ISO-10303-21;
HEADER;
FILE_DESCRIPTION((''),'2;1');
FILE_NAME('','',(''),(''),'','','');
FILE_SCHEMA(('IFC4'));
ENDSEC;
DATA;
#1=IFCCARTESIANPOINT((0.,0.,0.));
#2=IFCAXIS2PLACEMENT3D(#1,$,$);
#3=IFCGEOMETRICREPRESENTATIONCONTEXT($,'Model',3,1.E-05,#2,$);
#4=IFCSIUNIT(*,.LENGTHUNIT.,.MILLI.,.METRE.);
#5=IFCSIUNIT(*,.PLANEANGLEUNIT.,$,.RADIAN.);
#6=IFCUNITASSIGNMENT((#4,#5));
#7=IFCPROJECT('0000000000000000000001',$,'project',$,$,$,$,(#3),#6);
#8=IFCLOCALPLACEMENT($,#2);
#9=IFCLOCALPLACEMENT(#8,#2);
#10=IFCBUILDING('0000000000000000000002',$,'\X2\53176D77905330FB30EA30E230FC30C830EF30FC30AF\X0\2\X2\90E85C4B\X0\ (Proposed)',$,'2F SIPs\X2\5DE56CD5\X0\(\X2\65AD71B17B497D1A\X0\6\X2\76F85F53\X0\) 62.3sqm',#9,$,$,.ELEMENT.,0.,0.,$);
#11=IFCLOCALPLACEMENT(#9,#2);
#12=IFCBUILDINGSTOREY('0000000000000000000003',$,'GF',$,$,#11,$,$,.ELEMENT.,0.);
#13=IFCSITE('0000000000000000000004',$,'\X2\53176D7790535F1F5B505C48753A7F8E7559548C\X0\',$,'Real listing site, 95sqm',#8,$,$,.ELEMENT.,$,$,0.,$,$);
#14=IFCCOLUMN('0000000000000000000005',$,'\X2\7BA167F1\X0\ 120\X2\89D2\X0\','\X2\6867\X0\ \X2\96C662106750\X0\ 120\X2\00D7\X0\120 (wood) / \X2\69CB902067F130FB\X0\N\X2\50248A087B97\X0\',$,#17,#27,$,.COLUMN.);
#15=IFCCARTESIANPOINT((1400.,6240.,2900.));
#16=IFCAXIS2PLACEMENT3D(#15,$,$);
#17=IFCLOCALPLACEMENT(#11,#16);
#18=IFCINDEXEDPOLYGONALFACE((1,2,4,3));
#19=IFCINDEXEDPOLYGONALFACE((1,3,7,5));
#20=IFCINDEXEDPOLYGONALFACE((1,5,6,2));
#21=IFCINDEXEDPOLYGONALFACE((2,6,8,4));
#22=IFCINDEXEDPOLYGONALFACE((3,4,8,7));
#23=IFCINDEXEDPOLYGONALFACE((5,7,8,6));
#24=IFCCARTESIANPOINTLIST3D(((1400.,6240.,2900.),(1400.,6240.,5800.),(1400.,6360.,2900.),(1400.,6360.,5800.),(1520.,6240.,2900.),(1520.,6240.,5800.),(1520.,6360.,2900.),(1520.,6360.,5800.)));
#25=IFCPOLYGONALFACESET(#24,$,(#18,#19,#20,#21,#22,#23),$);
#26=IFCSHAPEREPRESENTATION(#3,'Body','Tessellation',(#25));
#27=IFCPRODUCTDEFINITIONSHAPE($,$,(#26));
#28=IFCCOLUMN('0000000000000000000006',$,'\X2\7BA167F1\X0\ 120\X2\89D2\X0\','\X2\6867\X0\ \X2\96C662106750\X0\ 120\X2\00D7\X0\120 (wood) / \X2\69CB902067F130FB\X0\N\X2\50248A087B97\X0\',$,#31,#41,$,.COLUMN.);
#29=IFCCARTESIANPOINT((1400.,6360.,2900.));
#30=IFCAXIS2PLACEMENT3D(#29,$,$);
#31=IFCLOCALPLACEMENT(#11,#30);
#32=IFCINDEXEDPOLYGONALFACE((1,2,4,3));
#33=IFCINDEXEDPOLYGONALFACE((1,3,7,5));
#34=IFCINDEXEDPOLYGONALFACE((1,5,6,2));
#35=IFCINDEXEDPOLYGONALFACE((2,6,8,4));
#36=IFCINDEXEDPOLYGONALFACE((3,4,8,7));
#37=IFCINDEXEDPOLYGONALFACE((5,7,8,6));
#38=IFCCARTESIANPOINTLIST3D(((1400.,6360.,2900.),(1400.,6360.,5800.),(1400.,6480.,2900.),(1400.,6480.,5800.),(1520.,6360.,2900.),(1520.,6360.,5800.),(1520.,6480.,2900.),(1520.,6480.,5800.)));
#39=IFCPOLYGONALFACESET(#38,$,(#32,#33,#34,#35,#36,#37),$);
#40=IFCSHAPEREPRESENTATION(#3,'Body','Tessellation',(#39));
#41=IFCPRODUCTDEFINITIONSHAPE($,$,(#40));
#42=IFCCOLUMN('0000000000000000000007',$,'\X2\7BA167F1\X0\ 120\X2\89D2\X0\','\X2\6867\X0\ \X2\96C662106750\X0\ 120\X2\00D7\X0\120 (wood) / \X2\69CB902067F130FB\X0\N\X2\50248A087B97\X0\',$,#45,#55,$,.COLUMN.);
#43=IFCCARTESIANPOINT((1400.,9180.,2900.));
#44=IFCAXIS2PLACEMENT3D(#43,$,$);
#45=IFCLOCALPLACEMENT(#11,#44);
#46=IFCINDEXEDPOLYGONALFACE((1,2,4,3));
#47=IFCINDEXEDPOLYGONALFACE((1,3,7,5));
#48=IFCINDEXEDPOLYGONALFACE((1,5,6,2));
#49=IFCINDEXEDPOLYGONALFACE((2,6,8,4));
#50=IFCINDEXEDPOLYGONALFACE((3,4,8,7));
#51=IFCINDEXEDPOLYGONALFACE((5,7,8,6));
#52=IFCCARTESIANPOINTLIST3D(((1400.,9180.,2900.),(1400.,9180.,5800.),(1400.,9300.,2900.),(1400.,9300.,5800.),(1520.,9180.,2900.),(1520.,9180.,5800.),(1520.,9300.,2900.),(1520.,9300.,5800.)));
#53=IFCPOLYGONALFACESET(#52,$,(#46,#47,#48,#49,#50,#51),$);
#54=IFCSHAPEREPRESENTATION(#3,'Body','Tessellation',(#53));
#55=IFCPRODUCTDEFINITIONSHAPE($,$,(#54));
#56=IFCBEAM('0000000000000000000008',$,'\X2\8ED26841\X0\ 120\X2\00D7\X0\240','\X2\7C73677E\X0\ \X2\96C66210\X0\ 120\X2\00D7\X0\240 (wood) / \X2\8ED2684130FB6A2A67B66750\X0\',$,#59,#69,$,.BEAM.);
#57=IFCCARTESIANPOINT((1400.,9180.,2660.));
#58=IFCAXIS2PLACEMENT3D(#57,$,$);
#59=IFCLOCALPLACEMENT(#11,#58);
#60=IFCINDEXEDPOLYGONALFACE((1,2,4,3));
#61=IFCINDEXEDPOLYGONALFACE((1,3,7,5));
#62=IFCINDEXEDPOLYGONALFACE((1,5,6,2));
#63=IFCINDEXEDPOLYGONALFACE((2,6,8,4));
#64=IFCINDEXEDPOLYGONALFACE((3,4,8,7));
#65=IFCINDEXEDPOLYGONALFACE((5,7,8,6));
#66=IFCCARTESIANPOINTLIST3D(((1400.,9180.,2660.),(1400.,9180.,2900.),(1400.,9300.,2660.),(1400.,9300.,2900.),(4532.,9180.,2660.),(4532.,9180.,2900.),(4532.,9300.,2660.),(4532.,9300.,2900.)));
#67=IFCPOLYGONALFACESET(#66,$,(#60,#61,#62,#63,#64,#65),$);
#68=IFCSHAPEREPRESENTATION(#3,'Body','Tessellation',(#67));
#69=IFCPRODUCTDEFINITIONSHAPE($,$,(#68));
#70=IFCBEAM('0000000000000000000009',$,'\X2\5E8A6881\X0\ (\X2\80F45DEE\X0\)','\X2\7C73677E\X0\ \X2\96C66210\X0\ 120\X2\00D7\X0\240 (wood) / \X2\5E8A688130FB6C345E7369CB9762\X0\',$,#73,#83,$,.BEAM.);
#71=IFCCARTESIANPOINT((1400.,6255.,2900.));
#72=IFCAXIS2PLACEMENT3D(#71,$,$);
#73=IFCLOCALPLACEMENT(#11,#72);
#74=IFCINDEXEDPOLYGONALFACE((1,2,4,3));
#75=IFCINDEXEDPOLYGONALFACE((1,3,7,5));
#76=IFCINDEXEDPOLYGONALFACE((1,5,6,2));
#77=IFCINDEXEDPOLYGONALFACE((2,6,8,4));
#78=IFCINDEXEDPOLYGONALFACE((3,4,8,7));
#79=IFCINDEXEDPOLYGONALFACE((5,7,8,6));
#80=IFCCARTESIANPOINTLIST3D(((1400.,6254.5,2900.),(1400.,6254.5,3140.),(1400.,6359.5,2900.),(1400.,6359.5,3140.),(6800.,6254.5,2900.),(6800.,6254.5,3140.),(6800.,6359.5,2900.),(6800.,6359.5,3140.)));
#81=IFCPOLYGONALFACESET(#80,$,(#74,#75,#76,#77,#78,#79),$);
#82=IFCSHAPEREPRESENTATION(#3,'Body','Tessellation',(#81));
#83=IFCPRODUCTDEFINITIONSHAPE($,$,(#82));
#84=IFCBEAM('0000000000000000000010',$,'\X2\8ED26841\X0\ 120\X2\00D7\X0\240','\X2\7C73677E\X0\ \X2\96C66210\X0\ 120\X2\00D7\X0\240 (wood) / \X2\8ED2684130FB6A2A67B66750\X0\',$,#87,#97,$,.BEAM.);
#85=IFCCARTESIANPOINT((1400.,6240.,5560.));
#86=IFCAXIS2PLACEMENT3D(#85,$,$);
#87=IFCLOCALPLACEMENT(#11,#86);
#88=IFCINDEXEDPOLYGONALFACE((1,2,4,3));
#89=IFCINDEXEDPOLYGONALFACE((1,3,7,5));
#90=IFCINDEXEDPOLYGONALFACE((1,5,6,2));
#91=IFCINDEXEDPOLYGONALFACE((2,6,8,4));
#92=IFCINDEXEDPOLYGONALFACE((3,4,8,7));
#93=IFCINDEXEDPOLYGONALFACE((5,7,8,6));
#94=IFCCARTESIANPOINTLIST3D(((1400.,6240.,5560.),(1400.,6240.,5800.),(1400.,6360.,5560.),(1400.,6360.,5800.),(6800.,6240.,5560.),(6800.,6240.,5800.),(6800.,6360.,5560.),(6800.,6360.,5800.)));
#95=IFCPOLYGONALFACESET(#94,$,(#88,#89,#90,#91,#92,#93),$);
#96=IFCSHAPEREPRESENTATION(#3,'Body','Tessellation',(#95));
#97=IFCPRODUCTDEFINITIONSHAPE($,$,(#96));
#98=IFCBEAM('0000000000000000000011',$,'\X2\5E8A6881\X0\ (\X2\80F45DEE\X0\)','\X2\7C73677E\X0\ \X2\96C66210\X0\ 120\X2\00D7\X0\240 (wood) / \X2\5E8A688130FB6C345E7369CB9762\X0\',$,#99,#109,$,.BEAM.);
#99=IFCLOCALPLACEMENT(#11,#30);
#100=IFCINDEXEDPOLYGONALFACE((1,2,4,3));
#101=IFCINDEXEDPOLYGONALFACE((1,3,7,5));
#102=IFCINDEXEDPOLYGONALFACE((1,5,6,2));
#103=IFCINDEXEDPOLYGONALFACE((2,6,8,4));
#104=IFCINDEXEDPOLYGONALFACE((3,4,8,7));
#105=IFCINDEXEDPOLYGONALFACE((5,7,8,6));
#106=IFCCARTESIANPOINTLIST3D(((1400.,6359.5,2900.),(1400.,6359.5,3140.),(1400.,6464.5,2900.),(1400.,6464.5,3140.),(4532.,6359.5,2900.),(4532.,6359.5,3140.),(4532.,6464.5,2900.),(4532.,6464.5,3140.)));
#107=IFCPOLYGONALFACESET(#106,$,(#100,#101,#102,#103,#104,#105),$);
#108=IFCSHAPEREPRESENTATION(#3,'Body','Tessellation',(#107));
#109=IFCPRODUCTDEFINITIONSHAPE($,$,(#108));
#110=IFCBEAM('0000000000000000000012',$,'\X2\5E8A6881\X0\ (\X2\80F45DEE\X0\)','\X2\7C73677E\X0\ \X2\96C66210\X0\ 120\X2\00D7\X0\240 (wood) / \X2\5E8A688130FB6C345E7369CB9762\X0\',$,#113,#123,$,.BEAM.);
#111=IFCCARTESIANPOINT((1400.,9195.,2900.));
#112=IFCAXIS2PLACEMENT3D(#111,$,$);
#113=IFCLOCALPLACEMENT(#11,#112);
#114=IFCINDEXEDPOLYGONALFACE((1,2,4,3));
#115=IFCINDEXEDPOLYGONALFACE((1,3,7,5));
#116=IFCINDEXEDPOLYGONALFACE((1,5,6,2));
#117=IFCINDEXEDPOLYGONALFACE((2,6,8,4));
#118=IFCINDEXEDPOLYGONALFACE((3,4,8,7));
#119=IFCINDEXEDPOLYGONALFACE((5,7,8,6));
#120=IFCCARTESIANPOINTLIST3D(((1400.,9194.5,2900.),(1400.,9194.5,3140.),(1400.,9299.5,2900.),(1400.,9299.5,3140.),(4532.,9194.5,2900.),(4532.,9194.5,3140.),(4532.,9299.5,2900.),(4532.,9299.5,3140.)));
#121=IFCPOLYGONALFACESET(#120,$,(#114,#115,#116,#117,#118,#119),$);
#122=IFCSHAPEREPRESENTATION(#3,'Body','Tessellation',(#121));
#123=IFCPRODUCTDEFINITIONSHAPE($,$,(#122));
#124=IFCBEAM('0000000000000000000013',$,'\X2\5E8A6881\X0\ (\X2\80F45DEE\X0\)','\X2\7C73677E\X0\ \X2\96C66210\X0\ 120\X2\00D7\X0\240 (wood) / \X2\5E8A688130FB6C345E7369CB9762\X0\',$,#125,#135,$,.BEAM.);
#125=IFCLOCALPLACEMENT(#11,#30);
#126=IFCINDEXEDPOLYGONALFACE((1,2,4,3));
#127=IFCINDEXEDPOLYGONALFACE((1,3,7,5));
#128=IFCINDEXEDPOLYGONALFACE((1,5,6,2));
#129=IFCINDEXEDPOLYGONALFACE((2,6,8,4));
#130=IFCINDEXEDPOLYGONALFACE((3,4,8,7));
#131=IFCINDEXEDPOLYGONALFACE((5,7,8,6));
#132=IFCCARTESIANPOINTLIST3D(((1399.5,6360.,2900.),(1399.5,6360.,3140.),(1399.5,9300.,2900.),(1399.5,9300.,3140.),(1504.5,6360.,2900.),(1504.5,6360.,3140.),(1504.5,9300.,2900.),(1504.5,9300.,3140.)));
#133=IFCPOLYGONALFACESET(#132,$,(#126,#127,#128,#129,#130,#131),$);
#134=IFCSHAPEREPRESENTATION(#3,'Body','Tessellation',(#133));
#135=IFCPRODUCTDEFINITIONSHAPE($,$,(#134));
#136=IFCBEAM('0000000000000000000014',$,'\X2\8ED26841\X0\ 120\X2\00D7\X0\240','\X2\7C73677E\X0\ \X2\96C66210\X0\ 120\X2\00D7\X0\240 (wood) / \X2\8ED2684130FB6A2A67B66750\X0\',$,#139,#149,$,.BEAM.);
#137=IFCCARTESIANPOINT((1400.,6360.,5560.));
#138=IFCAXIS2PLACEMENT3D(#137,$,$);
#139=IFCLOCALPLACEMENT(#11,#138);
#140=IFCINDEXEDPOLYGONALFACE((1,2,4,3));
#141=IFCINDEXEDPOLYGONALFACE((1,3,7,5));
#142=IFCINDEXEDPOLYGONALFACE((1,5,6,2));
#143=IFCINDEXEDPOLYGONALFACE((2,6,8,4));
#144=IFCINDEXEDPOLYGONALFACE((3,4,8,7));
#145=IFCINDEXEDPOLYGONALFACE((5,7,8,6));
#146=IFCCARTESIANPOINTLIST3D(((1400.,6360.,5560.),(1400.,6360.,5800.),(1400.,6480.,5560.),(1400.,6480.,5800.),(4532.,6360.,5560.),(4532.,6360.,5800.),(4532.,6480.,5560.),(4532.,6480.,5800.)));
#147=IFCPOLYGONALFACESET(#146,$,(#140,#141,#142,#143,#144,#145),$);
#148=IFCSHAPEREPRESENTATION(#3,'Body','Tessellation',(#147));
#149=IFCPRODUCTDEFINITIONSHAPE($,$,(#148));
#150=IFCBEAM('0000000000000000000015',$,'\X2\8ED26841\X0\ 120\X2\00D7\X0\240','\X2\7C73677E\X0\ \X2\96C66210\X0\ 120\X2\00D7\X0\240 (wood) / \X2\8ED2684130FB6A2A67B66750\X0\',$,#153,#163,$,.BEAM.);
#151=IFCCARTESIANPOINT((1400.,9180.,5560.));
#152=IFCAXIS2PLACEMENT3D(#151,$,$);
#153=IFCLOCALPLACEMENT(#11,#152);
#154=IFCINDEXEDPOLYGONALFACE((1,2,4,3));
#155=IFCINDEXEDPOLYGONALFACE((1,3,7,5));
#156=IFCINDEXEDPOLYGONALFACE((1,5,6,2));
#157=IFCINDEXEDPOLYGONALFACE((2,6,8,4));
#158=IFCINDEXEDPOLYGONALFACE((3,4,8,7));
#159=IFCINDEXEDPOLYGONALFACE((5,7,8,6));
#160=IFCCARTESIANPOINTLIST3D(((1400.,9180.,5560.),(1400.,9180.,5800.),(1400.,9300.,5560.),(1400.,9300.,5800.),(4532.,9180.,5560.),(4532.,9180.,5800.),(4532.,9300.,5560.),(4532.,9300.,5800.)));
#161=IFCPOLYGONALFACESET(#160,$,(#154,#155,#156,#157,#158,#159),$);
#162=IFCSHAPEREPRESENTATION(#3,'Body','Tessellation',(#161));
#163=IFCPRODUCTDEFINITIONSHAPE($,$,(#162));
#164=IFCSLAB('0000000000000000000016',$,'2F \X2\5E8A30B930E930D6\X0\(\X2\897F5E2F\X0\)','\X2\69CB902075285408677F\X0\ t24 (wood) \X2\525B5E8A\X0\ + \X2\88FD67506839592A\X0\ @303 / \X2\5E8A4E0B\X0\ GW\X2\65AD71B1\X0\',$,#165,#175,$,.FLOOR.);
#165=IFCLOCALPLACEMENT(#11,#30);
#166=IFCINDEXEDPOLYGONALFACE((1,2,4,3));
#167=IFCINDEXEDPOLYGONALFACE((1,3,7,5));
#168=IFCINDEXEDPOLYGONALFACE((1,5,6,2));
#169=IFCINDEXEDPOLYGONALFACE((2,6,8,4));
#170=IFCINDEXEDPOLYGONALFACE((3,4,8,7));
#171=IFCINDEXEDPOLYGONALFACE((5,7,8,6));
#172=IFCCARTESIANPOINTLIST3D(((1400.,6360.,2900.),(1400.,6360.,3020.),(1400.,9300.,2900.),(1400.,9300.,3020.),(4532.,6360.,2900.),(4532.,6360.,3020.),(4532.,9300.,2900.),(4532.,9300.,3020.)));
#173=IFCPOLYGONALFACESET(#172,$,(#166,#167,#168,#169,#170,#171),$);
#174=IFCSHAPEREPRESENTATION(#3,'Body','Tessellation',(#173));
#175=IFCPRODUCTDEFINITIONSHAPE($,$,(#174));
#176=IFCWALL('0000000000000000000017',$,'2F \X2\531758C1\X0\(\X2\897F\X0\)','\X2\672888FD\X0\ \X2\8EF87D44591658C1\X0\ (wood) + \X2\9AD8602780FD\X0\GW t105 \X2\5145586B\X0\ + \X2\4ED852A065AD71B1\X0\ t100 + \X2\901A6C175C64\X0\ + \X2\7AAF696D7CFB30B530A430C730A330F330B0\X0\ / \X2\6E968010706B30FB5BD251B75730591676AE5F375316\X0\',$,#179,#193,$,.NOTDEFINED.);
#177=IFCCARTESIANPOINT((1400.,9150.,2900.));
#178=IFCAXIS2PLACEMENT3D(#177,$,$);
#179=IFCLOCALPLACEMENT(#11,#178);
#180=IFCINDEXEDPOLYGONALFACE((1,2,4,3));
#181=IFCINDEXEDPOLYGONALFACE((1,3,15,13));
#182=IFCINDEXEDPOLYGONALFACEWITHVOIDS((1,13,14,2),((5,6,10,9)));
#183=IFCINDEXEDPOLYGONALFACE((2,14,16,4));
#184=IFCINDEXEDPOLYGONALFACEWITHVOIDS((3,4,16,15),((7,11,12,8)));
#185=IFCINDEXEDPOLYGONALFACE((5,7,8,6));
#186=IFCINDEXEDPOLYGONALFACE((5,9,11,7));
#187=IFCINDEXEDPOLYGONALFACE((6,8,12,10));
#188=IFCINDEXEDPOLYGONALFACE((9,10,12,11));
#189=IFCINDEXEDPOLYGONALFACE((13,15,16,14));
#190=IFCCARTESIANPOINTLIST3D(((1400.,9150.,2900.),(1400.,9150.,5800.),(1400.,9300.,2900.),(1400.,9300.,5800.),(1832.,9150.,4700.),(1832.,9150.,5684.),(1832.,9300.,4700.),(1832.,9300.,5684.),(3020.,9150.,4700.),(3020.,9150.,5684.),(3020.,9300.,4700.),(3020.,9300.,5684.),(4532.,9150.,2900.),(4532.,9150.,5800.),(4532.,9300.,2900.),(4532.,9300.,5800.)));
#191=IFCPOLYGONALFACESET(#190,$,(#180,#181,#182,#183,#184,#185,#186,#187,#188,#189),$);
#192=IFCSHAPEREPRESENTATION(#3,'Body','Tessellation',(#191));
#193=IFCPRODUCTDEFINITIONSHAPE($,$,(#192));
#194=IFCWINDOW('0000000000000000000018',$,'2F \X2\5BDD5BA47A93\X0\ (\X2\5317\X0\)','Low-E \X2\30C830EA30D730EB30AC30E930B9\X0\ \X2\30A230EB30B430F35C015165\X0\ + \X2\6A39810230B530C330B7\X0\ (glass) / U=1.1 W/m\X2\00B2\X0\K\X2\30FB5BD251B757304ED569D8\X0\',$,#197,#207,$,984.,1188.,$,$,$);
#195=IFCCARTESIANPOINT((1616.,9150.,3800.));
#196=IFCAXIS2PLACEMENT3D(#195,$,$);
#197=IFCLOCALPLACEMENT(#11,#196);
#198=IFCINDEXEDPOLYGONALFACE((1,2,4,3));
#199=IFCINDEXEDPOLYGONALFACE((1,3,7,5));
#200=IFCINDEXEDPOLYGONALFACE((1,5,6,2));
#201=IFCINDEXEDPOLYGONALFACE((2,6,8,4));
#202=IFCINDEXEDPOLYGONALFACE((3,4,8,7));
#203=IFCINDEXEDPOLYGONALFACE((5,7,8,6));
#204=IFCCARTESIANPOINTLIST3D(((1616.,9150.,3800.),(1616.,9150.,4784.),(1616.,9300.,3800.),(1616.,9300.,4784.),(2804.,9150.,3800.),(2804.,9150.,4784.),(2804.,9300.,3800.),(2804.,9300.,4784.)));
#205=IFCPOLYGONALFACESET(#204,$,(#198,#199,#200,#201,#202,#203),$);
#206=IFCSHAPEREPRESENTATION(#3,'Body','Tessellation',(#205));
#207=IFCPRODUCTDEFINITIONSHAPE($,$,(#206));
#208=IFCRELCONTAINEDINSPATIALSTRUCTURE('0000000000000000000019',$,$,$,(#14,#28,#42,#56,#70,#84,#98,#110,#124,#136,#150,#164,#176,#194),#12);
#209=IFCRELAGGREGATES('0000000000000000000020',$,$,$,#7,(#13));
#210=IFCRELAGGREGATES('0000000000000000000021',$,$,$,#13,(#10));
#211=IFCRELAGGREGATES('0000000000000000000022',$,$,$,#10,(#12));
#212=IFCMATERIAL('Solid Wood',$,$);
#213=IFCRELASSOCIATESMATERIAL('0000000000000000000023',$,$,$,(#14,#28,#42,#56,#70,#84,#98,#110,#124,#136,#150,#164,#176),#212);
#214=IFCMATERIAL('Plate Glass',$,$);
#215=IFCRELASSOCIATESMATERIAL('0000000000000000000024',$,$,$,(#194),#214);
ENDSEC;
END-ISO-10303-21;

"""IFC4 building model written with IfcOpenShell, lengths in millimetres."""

from ifc_helpers import new_model, si_unit, frame, frame_2d, origin, place, context, project, spatial, rectangle, extrude, material, element, fill, save


model = new_model("IFC4")

# Units and contexts
model_context = context("Model", 3, precision=1e-05, world=origin())
ifc_project = project(units=[si_unit("LENGTHUNIT", "METRE", prefix="MILLI"), si_unit("PLANEANGLEUNIT", "RADIAN")], contexts=[model_context])

# Site, building, storey
site_placement = place(None, origin())
site = spatial("IfcSite", under=ifc_project, at=site_placement, Name="北海道弟子屈町美留和", ObjectType="Real listing site, 95sqm", CompositionType="ELEMENT", RefElevation=0.0)
building_placement = place(site_placement, origin())
building = spatial("IfcBuilding", under=site, at=building_placement, Name="北海道・リモートワーク2部屋 (Proposed)", ObjectType="2F SIPs工法(断熱等級6相当) 62.3sqm", CompositionType="ELEMENT", ElevationOfRefHeight=0.0, ElevationOfTerrain=0.0)
storey_placement = place(building_placement, origin())
storey = spatial("IfcBuildingStorey", under=building, at=storey_placement, Name="GF", CompositionType="ELEMENT", Elevation=0.0)

# Columns
ifc_material_1 = material(Name="Solid Wood")
column_1_placement = place(storey_placement, frame((1400.0, 6240.0, 2900.0)))
element("IfcColumn", 1, at=column_1_placement, inside=storey, material=ifc_material_1, Name="管柱 120角", Description="桧 集成材 120×120 (wood) / 構造柱・N値計算", PredefinedType="COLUMN", context=model_context, shape_type="SweptSolid", body=[
    extrude(rectangle(XDim=120.0, YDim=120.0, at=frame_2d((60.0, 60.0))), frame((1400.0, 6240.0, 2900.0)), (0.0, 0.0, 1.0), 2900.0),
])
column_2_placement = place(storey_placement, frame((1400.0, 6360.0, 2900.0)))
element("IfcColumn", 2, at=column_2_placement, inside=storey, material=ifc_material_1, Name="管柱 120角", Description="桧 集成材 120×120 (wood) / 構造柱・N値計算", PredefinedType="COLUMN", context=model_context, shape_type="SweptSolid", body=[
    extrude(rectangle(XDim=120.0, YDim=120.0, at=frame_2d((60.0, 60.0))), frame((1400.0, 6360.0, 2900.0)), (0.0, 0.0, 1.0), 2900.0),
])
column_3_placement = place(storey_placement, frame((1400.0, 9180.0, 2900.0)))
element("IfcColumn", 3, at=column_3_placement, inside=storey, material=ifc_material_1, Name="管柱 120角", Description="桧 集成材 120×120 (wood) / 構造柱・N値計算", PredefinedType="COLUMN", context=model_context, shape_type="SweptSolid", body=[
    extrude(rectangle(XDim=120.0, YDim=120.0, at=frame_2d((60.0, 60.0))), frame((1400.0, 9180.0, 2900.0)), (0.0, 0.0, 1.0), 2900.0),
])

# Beams
beam_1_placement = place(storey_placement, frame((1400.0, 9180.0, 2660.0)))
element("IfcBeam", 4, at=beam_1_placement, inside=storey, material=ifc_material_1, Name="軒桁 120×240", Description="米松 集成 120×240 (wood) / 軒桁・横架材", PredefinedType="BEAM", context=model_context, shape_type="SweptSolid", body=[
    extrude(rectangle(XDim=3132.0, YDim=120.0, at=frame_2d((1566.0, 60.0))), frame((1400.0, 9180.0, 2660.0)), (0.0, 0.0, 1.0), 240.0),
])
beam_2_placement = place(storey_placement, frame((1400.0, 6255.0, 2900.0)))
element("IfcBeam", 5, at=beam_2_placement, inside=storey, material=ifc_material_1, Name="床梁 (胴差)", Description="米松 集成 120×240 (wood) / 床梁・水平構面", PredefinedType="BEAM", context=model_context, shape_type="SweptSolid", body=[
    extrude(rectangle(XDim=5400.0, YDim=105.0, at=frame_2d((2700.0, 52.0))), frame((1400.0, 6255.0, 2900.0)), (0.0, 0.0, 1.0), 240.0),
])
beam_3_placement = place(storey_placement, frame((1400.0, 6240.0, 5560.0)))
element("IfcBeam", 6, at=beam_3_placement, inside=storey, material=ifc_material_1, Name="軒桁 120×240", Description="米松 集成 120×240 (wood) / 軒桁・横架材", PredefinedType="BEAM", context=model_context, shape_type="SweptSolid", body=[
    extrude(rectangle(XDim=5400.0, YDim=120.0, at=frame_2d((2700.0, 60.0))), frame((1400.0, 6240.0, 5560.0)), (0.0, 0.0, 1.0), 240.0),
])
beam_4_placement = place(storey_placement, frame((1400.0, 6360.0, 2900.0)))
element("IfcBeam", 7, at=beam_4_placement, inside=storey, material=ifc_material_1, Name="床梁 (胴差)", Description="米松 集成 120×240 (wood) / 床梁・水平構面", PredefinedType="BEAM", context=model_context, shape_type="SweptSolid", body=[
    extrude(rectangle(XDim=3132.0, YDim=105.0, at=frame_2d((1566.0, 52.0))), frame((1400.0, 6360.0, 2900.0)), (0.0, 0.0, 1.0), 240.0),
])
beam_5_placement = place(storey_placement, frame((1400.0, 9195.0, 2900.0)))
element("IfcBeam", 8, at=beam_5_placement, inside=storey, material=ifc_material_1, Name="床梁 (胴差)", Description="米松 集成 120×240 (wood) / 床梁・水平構面", PredefinedType="BEAM", context=model_context, shape_type="SweptSolid", body=[
    extrude(rectangle(XDim=3132.0, YDim=105.0, at=frame_2d((1566.0, 52.0))), frame((1400.0, 9195.0, 2900.0)), (0.0, 0.0, 1.0), 240.0),
])
beam_6_placement = place(storey_placement, frame((1400.0, 6360.0, 2900.0)))
element("IfcBeam", 9, at=beam_6_placement, inside=storey, material=ifc_material_1, Name="床梁 (胴差)", Description="米松 集成 120×240 (wood) / 床梁・水平構面", PredefinedType="BEAM", context=model_context, shape_type="SweptSolid", body=[
    extrude(rectangle(XDim=105.0, YDim=2940.0, at=frame_2d((52.0, 1470.0))), frame((1400.0, 6360.0, 2900.0)), (0.0, 0.0, 1.0), 240.0),
])
beam_7_placement = place(storey_placement, frame((1400.0, 6360.0, 5560.0)))
element("IfcBeam", 10, at=beam_7_placement, inside=storey, material=ifc_material_1, Name="軒桁 120×240", Description="米松 集成 120×240 (wood) / 軒桁・横架材", PredefinedType="BEAM", context=model_context, shape_type="SweptSolid", body=[
    extrude(rectangle(XDim=3132.0, YDim=120.0, at=frame_2d((1566.0, 60.0))), frame((1400.0, 6360.0, 5560.0)), (0.0, 0.0, 1.0), 240.0),
])
beam_8_placement = place(storey_placement, frame((1400.0, 9180.0, 5560.0)))
element("IfcBeam", 11, at=beam_8_placement, inside=storey, material=ifc_material_1, Name="軒桁 120×240", Description="米松 集成 120×240 (wood) / 軒桁・横架材", PredefinedType="BEAM", context=model_context, shape_type="SweptSolid", body=[
    extrude(rectangle(XDim=3132.0, YDim=120.0, at=frame_2d((1566.0, 60.0))), frame((1400.0, 9180.0, 5560.0)), (0.0, 0.0, 1.0), 240.0),
])

# Slab
slab_placement = place(storey_placement, frame((1400.0, 6360.0, 2900.0)))
element("IfcSlab", 12, at=slab_placement, inside=storey, material=ifc_material_1, Name="2F 床スラブ(西帯)", Description="構造用合板 t24 (wood) 剛床 + 製材根太 @303 / 床下 GW断熱", PredefinedType="FLOOR", context=model_context, shape_type="SweptSolid", body=[
    extrude(rectangle(XDim=3132.0, YDim=2940.0, at=frame_2d((1566.0, 1470.0))), frame((1400.0, 6360.0, 2900.0)), (0.0, 0.0, 1.0), 120.0),
])

# Wall, opening, window
wall_1_placement = place(storey_placement, frame((1400.0, 9150.0, 2900.0)))
wall_1 = element("IfcWall", 13, at=wall_1_placement, inside=storey, material=ifc_material_1, Name="2F 北壁(西)", Description="木製 軸組外壁 (wood) + 高性能GW t105 充填 + 付加断熱 t100 + 通気層 + 窯業系サイディング / 準耐火・寒冷地外皮強化", PredefinedType="NOTDEFINED", context=model_context, shape_type="SweptSolid", body=[
    extrude(rectangle(XDim=3132.0, YDim=150.0, at=frame_2d((1566.0, 75.0))), frame((1400.0, 9150.0, 2900.0)), (0.0, 0.0, 1.0), 2900.0),
])
opening_placement = place(storey_placement, frame((1616.0, 9150.0, 3800.0)))
opening = element("IfcOpeningElement", 14, at=opening_placement, cuts=wall_1, PredefinedType="NOTDEFINED", context=model_context, shape_type="SweptSolid", body=[
    extrude(rectangle(XDim=1188.0, YDim=150.0, at=frame_2d((594.0, 75.0))), frame((1616.0, 9150.0, 3800.0)), (0.0, 0.0, 1.0), 984.0),
])
ifc_material_2 = material(Name="Plate Glass")
window_placement = place(storey_placement, frame((1616.0, 9150.0, 3800.0)))
window = element("IfcWindow", 15, at=window_placement, inside=storey, material=ifc_material_2, Name="2F 寝室窓 (北)", Description="Low-E トリプルガラス アルゴン封入 + 樹脂サッシ (glass) / U=1.1 W/m²K・寒冷地仕様", OverallHeight=984.0, OverallWidth=1188.0, context=model_context, shape_type="SweptSolid", body=[
    extrude(rectangle(XDim=1188.0, YDim=150.0, at=frame_2d((594.0, 75.0))), frame((1616.0, 9150.0, 3800.0)), (0.0, 0.0, 1.0), 984.0),
])
fill(opening, window)

save(model, "model.ifc")
